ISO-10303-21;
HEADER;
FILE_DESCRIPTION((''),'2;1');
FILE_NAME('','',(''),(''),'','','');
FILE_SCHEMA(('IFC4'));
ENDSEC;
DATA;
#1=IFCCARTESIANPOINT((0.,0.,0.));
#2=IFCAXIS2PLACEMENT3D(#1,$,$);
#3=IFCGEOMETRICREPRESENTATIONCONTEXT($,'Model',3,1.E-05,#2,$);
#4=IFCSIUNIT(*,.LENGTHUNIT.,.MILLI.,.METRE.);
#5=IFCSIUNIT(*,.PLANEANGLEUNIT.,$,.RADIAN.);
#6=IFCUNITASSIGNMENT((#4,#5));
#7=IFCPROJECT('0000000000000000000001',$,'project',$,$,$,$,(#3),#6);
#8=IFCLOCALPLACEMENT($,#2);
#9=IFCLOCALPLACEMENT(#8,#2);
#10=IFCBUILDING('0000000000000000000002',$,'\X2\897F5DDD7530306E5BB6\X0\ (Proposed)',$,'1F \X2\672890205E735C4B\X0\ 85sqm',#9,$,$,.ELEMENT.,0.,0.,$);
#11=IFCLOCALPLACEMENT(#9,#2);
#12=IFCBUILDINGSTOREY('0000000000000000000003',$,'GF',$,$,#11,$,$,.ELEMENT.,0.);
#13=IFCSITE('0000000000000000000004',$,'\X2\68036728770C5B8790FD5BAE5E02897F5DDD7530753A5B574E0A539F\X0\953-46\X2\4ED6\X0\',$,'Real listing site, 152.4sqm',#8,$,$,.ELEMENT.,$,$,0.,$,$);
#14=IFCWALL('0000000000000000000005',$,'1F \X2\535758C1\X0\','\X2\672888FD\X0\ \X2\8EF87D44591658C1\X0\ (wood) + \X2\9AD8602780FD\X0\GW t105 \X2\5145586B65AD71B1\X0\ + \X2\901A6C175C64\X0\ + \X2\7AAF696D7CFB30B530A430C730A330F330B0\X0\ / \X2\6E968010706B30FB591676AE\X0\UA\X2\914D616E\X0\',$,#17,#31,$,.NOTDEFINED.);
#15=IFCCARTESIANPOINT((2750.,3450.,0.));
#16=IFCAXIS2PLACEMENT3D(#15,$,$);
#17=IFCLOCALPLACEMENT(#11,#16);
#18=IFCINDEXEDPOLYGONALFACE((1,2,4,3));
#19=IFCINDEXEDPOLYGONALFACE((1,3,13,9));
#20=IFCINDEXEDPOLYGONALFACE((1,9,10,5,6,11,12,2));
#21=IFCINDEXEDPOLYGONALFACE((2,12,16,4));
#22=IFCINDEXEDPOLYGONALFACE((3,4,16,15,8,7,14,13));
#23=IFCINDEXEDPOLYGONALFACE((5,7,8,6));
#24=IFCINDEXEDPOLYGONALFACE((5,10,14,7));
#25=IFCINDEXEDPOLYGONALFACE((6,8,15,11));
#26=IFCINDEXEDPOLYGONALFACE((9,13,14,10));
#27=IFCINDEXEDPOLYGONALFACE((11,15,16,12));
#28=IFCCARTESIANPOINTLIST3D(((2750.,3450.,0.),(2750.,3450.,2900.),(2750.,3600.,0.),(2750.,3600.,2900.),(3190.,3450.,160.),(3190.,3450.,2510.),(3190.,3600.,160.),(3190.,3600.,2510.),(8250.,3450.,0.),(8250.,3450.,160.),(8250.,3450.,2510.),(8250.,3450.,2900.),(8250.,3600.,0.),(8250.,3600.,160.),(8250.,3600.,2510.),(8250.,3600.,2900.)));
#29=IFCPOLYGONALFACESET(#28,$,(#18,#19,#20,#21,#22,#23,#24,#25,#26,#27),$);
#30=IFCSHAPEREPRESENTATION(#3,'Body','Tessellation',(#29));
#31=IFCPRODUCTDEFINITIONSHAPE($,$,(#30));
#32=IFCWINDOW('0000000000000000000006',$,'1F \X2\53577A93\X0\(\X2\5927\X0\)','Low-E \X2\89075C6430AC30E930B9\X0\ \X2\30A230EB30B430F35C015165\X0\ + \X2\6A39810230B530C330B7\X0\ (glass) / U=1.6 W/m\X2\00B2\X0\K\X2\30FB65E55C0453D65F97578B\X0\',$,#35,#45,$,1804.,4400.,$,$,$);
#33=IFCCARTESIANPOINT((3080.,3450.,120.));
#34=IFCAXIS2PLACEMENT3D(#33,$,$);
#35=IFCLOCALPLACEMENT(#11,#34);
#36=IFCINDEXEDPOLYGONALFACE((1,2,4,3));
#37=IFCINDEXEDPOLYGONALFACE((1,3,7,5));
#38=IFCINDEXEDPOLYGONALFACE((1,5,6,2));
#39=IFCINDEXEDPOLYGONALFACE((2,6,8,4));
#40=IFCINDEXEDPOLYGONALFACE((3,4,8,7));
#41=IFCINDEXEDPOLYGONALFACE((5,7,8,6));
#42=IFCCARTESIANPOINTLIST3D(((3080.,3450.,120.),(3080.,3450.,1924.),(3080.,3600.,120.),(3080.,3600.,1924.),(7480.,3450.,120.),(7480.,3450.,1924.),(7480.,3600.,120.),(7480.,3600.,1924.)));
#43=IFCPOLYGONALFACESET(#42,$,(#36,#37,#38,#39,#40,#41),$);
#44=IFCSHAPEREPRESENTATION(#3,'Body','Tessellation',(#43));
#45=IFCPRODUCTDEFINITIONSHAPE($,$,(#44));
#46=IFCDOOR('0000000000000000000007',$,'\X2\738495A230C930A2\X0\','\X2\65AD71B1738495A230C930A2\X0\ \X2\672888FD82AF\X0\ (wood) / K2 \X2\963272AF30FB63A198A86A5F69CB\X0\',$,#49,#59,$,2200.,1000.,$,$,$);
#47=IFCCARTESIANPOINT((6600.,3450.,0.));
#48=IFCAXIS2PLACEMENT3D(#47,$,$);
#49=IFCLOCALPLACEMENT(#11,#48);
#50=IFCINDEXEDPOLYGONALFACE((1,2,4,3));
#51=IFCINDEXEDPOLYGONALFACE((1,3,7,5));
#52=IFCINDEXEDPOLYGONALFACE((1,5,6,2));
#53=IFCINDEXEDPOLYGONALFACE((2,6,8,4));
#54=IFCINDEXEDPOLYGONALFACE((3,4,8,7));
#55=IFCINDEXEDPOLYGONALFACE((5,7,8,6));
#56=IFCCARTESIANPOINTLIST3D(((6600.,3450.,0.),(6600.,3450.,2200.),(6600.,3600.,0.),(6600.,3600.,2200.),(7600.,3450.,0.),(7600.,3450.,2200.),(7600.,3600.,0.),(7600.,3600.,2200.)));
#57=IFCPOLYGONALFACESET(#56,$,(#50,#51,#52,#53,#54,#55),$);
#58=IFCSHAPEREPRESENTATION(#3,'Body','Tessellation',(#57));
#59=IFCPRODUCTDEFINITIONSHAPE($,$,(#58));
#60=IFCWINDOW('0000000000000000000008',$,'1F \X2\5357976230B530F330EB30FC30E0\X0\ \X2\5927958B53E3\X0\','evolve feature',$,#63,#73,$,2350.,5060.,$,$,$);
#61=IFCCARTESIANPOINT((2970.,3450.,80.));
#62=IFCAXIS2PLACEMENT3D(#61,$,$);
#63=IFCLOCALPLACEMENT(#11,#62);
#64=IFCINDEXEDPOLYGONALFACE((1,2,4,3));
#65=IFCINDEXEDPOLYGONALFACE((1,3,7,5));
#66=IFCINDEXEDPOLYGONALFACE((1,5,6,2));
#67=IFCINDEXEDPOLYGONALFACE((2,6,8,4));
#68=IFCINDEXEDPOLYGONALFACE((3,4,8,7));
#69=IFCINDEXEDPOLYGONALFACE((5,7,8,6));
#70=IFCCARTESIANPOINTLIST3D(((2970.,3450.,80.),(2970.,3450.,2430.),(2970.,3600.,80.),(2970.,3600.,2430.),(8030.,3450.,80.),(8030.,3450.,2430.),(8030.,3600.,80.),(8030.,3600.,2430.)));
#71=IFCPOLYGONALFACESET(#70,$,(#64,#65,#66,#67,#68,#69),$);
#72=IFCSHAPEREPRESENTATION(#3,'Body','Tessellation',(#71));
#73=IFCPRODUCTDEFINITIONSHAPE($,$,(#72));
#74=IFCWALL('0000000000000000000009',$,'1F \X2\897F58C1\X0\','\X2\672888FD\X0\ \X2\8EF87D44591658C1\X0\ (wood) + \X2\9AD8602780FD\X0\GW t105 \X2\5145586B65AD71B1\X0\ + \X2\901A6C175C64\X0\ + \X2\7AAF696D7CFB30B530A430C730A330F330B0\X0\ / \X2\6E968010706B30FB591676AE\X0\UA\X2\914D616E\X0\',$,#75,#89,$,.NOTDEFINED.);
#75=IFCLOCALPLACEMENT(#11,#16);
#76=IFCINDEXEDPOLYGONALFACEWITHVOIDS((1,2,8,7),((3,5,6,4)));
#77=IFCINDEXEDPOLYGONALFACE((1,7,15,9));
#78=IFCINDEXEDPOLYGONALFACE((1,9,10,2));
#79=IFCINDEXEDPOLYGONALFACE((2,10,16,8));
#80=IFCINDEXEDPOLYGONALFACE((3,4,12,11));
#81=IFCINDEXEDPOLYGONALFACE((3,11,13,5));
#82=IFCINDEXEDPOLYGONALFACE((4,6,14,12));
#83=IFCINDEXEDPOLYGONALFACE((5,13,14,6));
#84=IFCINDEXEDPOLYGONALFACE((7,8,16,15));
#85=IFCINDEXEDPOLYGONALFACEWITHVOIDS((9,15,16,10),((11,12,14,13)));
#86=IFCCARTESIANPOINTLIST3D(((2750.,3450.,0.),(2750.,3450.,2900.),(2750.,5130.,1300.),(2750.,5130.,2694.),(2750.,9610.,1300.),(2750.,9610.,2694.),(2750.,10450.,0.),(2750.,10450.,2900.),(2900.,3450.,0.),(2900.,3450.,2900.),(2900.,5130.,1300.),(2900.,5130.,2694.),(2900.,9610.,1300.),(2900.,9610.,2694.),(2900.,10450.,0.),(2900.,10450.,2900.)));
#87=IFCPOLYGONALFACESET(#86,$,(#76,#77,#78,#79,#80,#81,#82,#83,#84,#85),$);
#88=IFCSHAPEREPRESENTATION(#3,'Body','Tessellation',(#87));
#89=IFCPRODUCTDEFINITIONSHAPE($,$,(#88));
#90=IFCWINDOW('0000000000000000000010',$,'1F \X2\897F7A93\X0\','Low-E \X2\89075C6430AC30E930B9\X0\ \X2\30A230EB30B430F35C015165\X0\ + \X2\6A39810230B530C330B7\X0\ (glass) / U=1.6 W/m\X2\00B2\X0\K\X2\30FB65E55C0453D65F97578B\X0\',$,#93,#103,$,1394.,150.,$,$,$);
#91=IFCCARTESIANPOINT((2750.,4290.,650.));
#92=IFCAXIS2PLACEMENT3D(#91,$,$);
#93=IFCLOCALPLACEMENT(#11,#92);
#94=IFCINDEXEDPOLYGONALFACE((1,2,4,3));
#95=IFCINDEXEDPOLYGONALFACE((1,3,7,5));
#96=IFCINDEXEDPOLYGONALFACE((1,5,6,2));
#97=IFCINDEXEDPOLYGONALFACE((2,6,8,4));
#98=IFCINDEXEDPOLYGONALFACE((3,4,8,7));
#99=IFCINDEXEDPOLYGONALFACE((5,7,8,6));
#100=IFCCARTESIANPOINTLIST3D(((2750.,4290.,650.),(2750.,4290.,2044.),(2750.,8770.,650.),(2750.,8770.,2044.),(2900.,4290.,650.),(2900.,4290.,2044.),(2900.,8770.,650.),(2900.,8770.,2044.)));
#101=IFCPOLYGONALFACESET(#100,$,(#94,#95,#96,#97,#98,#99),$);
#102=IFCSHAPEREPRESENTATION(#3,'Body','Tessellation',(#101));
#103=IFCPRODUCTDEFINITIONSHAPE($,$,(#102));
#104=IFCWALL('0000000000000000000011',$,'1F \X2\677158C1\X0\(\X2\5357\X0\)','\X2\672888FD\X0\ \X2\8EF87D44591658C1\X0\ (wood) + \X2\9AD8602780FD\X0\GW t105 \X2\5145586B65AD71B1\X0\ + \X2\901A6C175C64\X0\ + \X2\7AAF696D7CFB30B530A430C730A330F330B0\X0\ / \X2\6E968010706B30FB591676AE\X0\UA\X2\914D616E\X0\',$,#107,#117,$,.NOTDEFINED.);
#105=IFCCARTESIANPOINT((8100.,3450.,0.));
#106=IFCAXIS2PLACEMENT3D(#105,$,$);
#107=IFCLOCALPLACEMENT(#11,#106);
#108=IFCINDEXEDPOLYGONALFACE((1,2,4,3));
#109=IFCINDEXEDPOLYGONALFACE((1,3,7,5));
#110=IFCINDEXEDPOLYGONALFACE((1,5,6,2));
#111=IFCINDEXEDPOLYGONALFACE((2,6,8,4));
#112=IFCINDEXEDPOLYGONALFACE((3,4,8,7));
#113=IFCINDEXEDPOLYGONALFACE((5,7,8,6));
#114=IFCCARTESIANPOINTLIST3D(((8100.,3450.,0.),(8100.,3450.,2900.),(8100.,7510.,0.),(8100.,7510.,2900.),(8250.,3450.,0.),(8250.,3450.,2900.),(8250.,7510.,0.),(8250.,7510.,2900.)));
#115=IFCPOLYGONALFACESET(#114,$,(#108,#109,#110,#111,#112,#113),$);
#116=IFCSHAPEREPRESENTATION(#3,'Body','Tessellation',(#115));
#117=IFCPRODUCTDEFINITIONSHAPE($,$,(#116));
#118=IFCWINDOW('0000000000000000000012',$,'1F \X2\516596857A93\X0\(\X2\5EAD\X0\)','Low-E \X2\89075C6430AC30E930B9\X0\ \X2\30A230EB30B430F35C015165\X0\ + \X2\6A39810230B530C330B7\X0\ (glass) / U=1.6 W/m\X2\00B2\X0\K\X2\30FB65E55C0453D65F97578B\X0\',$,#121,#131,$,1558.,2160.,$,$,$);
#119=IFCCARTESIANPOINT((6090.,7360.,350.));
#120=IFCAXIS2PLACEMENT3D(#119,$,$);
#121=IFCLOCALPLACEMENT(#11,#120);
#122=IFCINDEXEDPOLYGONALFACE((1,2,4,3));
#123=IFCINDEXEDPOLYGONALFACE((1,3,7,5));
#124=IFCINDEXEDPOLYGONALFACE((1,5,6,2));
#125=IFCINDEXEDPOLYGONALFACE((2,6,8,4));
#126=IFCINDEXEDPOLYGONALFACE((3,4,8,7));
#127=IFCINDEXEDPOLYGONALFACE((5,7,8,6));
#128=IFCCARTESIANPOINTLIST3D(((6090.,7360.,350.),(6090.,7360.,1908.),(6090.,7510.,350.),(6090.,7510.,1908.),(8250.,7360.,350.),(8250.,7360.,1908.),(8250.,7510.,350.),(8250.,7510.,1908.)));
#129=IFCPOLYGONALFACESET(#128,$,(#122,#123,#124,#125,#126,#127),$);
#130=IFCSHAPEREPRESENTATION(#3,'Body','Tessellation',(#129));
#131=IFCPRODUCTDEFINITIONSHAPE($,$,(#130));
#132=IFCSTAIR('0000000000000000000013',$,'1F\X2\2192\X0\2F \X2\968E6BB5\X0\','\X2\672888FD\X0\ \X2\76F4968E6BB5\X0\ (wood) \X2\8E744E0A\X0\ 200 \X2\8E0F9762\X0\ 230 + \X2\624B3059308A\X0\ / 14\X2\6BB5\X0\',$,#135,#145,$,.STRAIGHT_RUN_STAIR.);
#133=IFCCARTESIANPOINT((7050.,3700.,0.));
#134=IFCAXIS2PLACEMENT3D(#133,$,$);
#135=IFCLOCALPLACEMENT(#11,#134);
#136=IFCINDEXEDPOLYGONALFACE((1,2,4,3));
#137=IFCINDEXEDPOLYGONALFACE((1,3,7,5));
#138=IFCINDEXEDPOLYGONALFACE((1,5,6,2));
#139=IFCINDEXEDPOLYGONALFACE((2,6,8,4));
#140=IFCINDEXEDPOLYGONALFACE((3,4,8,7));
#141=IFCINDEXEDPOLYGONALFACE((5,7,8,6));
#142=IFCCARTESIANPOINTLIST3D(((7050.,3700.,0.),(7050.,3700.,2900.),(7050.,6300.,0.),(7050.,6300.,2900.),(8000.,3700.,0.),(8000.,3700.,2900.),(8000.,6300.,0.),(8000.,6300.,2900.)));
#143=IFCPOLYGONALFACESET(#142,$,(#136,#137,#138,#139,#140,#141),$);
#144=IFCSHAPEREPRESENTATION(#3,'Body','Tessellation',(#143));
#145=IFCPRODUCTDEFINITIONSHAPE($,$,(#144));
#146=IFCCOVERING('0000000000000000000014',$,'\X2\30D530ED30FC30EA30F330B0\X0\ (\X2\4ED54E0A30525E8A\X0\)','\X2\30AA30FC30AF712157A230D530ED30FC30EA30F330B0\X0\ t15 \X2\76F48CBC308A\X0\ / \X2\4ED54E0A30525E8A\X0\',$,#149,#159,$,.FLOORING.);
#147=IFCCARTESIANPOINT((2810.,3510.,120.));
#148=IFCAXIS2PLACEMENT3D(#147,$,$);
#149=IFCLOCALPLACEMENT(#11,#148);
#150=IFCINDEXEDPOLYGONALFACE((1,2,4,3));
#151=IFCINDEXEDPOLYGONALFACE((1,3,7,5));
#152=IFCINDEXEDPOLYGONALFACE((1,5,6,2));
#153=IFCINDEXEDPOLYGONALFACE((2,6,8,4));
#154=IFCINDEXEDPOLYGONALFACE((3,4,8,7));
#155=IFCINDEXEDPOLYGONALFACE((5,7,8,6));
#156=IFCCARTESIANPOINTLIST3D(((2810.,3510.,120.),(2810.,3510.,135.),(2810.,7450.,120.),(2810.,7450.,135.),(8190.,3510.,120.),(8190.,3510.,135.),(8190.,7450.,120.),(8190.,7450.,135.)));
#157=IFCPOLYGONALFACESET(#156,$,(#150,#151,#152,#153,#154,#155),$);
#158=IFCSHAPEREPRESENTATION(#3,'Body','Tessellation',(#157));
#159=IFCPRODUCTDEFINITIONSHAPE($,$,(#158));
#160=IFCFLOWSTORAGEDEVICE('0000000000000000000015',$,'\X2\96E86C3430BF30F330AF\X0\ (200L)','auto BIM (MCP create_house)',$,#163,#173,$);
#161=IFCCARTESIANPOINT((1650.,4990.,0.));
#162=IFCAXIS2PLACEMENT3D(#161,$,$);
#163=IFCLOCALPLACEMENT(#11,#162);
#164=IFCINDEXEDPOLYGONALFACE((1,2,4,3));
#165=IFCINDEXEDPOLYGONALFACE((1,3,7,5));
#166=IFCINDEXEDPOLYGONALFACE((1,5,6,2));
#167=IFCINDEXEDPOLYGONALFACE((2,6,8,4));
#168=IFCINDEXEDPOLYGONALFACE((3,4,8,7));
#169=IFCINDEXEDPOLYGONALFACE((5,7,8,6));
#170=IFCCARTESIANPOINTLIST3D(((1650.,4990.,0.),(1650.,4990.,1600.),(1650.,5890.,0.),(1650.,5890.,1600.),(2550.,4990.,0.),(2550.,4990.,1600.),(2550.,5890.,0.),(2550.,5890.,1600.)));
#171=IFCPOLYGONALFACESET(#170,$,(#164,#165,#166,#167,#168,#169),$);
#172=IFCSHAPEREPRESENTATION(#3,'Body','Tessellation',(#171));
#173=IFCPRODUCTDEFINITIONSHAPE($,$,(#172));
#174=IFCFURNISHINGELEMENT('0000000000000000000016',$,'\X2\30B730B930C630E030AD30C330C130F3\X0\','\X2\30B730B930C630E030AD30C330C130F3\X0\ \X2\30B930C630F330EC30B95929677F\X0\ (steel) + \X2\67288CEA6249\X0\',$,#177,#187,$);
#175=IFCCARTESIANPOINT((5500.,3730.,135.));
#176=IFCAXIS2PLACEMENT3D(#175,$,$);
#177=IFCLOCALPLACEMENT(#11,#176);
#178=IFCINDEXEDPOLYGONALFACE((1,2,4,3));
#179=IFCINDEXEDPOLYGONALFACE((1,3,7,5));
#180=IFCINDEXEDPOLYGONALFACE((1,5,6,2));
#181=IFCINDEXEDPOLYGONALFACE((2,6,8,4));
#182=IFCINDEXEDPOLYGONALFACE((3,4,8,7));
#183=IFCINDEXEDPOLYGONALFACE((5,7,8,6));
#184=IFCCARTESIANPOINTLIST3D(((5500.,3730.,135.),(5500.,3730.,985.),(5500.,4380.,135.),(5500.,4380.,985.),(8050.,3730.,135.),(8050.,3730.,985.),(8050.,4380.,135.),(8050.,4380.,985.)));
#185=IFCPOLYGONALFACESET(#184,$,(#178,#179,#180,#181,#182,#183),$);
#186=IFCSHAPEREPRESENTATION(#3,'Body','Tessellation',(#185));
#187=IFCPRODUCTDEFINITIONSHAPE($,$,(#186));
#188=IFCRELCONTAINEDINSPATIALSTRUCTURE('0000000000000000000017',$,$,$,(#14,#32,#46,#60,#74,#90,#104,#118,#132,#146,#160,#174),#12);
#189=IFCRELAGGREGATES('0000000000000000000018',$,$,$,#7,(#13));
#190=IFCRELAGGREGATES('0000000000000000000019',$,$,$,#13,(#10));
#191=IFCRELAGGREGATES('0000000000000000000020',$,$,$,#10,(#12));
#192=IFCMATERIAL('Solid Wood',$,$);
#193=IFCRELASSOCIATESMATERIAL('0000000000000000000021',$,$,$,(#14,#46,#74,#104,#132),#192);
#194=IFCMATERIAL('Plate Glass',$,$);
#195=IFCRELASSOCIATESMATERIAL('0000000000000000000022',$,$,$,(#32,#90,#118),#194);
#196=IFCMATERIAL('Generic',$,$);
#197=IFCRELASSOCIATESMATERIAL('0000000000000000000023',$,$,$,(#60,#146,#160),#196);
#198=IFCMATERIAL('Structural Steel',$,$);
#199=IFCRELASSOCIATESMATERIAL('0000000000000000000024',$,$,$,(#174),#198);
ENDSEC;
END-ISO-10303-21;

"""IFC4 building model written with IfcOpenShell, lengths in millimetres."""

from ifc_helpers import new_model, si_unit, frame, frame_2d, origin, place, context, project, spatial, rectangle, extrude, material, element, fill, save


model = new_model("IFC4")

# Units and contexts
model_context = context("Model", 3, precision=1e-05, world=origin())
ifc_project = project(units=[si_unit("LENGTHUNIT", "METRE", prefix="MILLI"), si_unit("PLANEANGLEUNIT", "RADIAN")], contexts=[model_context])

# Site, building, storey
site_placement = place(None, origin())
site = spatial("IfcSite", under=ifc_project, at=site_placement, Name="栃木県宇都宮市西川田町字上原953-46他", ObjectType="Real listing site, 152.4sqm", CompositionType="ELEMENT", RefElevation=0.0)
building_placement = place(site_placement, origin())
building = spatial("IfcBuilding", under=site, at=building_placement, Name="西川田の家 (Proposed)", ObjectType="1F 木造平屋 85sqm", CompositionType="ELEMENT", ElevationOfRefHeight=0.0, ElevationOfTerrain=0.0)
storey_placement = place(building_placement, origin())
storey = spatial("IfcBuildingStorey", under=building, at=storey_placement, Name="GF", CompositionType="ELEMENT", Elevation=0.0)

# Shared definitions
ifc_material_1 = material(Name="Solid Wood")
ifc_material_2 = material(Name="Generic")

# Wall, openings, windows, door
wall_1_placement = place(storey_placement, frame((2750.0, 3450.0, 0.0)))
wall_1 = element("IfcWall", 1, at=wall_1_placement, inside=storey, material=ifc_material_1, Name="1F 南壁", Description="木製 軸組外壁 (wood) + 高性能GW t105 充填断熱 + 通気層 + 窯業系サイディング / 準耐火・外皮UA配慮", PredefinedType="NOTDEFINED", context=model_context, shape_type="SweptSolid", body=[
    extrude(rectangle(XDim=5500.0, YDim=150.0, at=frame_2d((2750.0, 75.0))), frame((2750.0, 3450.0, 0.0)), (0.0, 0.0, 1.0), 2900.0),
])
opening_1_placement = place(storey_placement, frame((3080.0, 3450.0, 120.0)))
opening_1 = element("IfcOpeningElement", 2, at=opening_1_placement, cuts=wall_1, PredefinedType="NOTDEFINED", context=model_context, shape_type="SweptSolid", body=[
    extrude(rectangle(XDim=4400.0, YDim=150.0, at=frame_2d((2200.0, 75.0))), frame((3080.0, 3450.0, 120.0)), (0.0, 0.0, 1.0), 1804.0),
])
opening_2_placement = place(storey_placement, frame((6600.0, 3450.0, 0.0)))
opening_2 = element("IfcOpeningElement", 3, at=opening_2_placement, cuts=wall_1, PredefinedType="NOTDEFINED", context=model_context, shape_type="SweptSolid", body=[
    extrude(rectangle(XDim=1000.0, YDim=150.0, at=frame_2d((500.0, 75.0))), frame((6600.0, 3450.0, 0.0)), (0.0, 0.0, 1.0), 2200.0),
])
opening_3_placement = place(storey_placement, frame((2970.0, 3450.0, 80.0)))
opening_3 = element("IfcOpeningElement", 4, at=opening_3_placement, cuts=wall_1, PredefinedType="NOTDEFINED", context=model_context, shape_type="SweptSolid", body=[
    extrude(rectangle(XDim=5060.0, YDim=150.0, at=frame_2d((2530.0, 75.0))), frame((2970.0, 3450.0, 80.0)), (0.0, 0.0, 1.0), 2350.0),
])
ifc_material_3 = material(Name="Plate Glass")
window_1_placement = place(storey_placement, frame((3080.0, 3450.0, 120.0)))
window_1 = element("IfcWindow", 5, at=window_1_placement, inside=storey, material=ifc_material_3, Name="1F 南窓(大)", Description="Low-E 複層ガラス アルゴン封入 + 樹脂サッシ (glass) / U=1.6 W/m²K・日射取得型", OverallHeight=1804.0, OverallWidth=4400.0, context=model_context, shape_type="SweptSolid", body=[
    extrude(rectangle(XDim=4400.0, YDim=150.0, at=frame_2d((2200.0, 75.0))), frame((3080.0, 3450.0, 120.0)), (0.0, 0.0, 1.0), 1804.0),
])
fill(opening_1, window_1)
door_1_placement = place(storey_placement, frame((6600.0, 3450.0, 0.0)))
door_1 = element("IfcDoor", 6, at=door_1_placement, inside=storey, material=ifc_material_1, Name="玄関ドア", Description="断熱玄関ドア 木製芯 (wood) / K2 防犯・採風機構", OverallHeight=2200.0, OverallWidth=1000.0, context=model_context, shape_type="SweptSolid", body=[
    extrude(rectangle(XDim=1000.0, YDim=150.0, at=frame_2d((500.0, 75.0))), frame((6600.0, 3450.0, 0.0)), (0.0, 0.0, 1.0), 2200.0),
])
fill(opening_2, door_1)
window_2_placement = place(storey_placement, frame((2970.0, 3450.0, 80.0)))
window_2 = element("IfcWindow", 7, at=window_2_placement, inside=storey, material=ifc_material_2, Name="1F 南面サンルーム 大開口", Description="evolve feature", OverallHeight=2350.0, OverallWidth=5060.0, context=model_context, shape_type="SweptSolid", body=[
    extrude(rectangle(XDim=5060.0, YDim=150.0, at=frame_2d((2530.0, 75.0))), frame((2970.0, 3450.0, 80.0)), (0.0, 0.0, 1.0), 2350.0),
])
fill(opening_3, window_2)

# Walls, openings, windows
wall_2_placement = place(storey_placement, frame((2750.0, 3450.0, 0.0)))
wall_2 = element("IfcWall", 8, at=wall_2_placement, inside=storey, material=ifc_material_1, Name="1F 西壁", Description="木製 軸組外壁 (wood) + 高性能GW t105 充填断熱 + 通気層 + 窯業系サイディング / 準耐火・外皮UA配慮", PredefinedType="NOTDEFINED", context=model_context, shape_type="SweptSolid", body=[
    extrude(rectangle(XDim=150.0, YDim=7000.0, at=frame_2d((75.0, 3500.0))), frame((2750.0, 3450.0, 0.0)), (0.0, 0.0, 1.0), 2900.0),
])
opening_4_placement = place(storey_placement, frame((2750.0, 4290.0, 650.0)))
opening_4 = element("IfcOpeningElement", 9, at=opening_4_placement, cuts=wall_2, PredefinedType="NOTDEFINED", context=model_context, shape_type="SweptSolid", body=[
    extrude(rectangle(XDim=150.0, YDim=4480.0, at=frame_2d((75.0, 2240.0))), frame((2750.0, 4290.0, 650.0)), (0.0, 0.0, 1.0), 1394.0),
])
window_3_placement = place(storey_placement, frame((2750.0, 4290.0, 650.0)))
window_3 = element("IfcWindow", 10, at=window_3_placement, inside=storey, material=ifc_material_3, Name="1F 西窓", Description="Low-E 複層ガラス アルゴン封入 + 樹脂サッシ (glass) / U=1.6 W/m²K・日射取得型", OverallHeight=1394.0, OverallWidth=150.0, context=model_context, shape_type="SweptSolid", body=[
    extrude(rectangle(XDim=150.0, YDim=4480.0, at=frame_2d((75.0, 2240.0))), frame((2750.0, 4290.0, 650.0)), (0.0, 0.0, 1.0), 1394.0),
])
fill(opening_4, window_3)
wall_3_placement = place(storey_placement, frame((8100.0, 3450.0, 0.0)))
wall_3 = element("IfcWall", 11, at=wall_3_placement, inside=storey, material=ifc_material_1, Name="1F 東壁(南)", Description="木製 軸組外壁 (wood) + 高性能GW t105 充填断熱 + 通気層 + 窯業系サイディング / 準耐火・外皮UA配慮", PredefinedType="NOTDEFINED", context=model_context, shape_type="SweptSolid", body=[
    extrude(rectangle(XDim=150.0, YDim=4060.0, at=frame_2d((75.0, 2030.0))), frame((8100.0, 3450.0, 0.0)), (0.0, 0.0, 1.0), 2900.0),
])
opening_5_placement = place(storey_placement, frame((6090.0, 7360.0, 350.0)))
opening_5 = element("IfcOpeningElement", 12, at=opening_5_placement, cuts=wall_3, PredefinedType="NOTDEFINED", context=model_context, shape_type="SweptSolid", body=[
    extrude(rectangle(XDim=2160.0, YDim=150.0, at=frame_2d((1080.0, 75.0))), frame((6090.0, 7360.0, 350.0)), (0.0, 0.0, 1.0), 1558.0),
])
window_4_placement = place(storey_placement, frame((6090.0, 7360.0, 350.0)))
window_4 = element("IfcWindow", 13, at=window_4_placement, inside=storey, material=ifc_material_3, Name="1F 入隅窓(庭)", Description="Low-E 複層ガラス アルゴン封入 + 樹脂サッシ (glass) / U=1.6 W/m²K・日射取得型", OverallHeight=1558.0, OverallWidth=2160.0, context=model_context, shape_type="SweptSolid", body=[
    extrude(rectangle(XDim=2160.0, YDim=150.0, at=frame_2d((1080.0, 75.0))), frame((6090.0, 7360.0, 350.0)), (0.0, 0.0, 1.0), 1558.0),
])
fill(opening_5, window_4)

# Stair
stair_placement = place(storey_placement, frame((7050.0, 3700.0, 0.0)))
element("IfcStair", 14, at=stair_placement, inside=storey, material=ifc_material_1, Name="1F→2F 階段", Description="木製 直階段 (wood) 蹴上 200 踏面 230 + 手すり / 14段", PredefinedType="STRAIGHT_RUN_STAIR", context=model_context, shape_type="SweptSolid", body=[
    extrude(rectangle(XDim=950.0, YDim=2600.0, at=frame_2d((475.0, 1300.0))), frame((7050.0, 3700.0, 0.0)), (0.0, 0.0, 1.0), 2900.0),
])

# Covering
covering_placement = place(storey_placement, frame((2810.0, 3510.0, 120.0)))
element("IfcCovering", 15, at=covering_placement, inside=storey, material=ifc_material_2, Name="フローリング (仕上げ床)", Description="オーク無垢フローリング t15 直貼り / 仕上げ床", PredefinedType="FLOORING", context=model_context, shape_type="SweptSolid", body=[
    extrude(rectangle(XDim=5380.0, YDim=3940.0, at=frame_2d((2690.0, 1970.0))), frame((2810.0, 3510.0, 120.0)), (0.0, 0.0, 1.0), 15.0),
])

# Flow storage device
flow_storage_device_placement = place(storey_placement, frame((1650.0, 4990.0, 0.0)))
element("IfcFlowStorageDevice", 16, at=flow_storage_device_placement, inside=storey, material=ifc_material_2, Name="雨水タンク (200L)", Description="auto BIM (MCP create_house)", context=model_context, shape_type="SweptSolid", body=[
    extrude(rectangle(XDim=900.0, YDim=900.0, at=frame_2d((450.0, 450.0))), frame((1650.0, 4990.0, 0.0)), (0.0, 0.0, 1.0), 1600.0),
])

# Furnishing element
ifc_material_4 = material(Name="Structural Steel")
furnishing_placement = place(storey_placement, frame((5500.0, 3730.0, 135.0)))
element("IfcFurnishingElement", 17, at=furnishing_placement, inside=storey, material=ifc_material_4, Name="システムキッチン", Description="システムキッチン ステンレス天板 (steel) + 木質扉", context=model_context, shape_type="SweptSolid", body=[
    extrude(rectangle(XDim=2550.0, YDim=650.0, at=frame_2d((1275.0, 325.0))), frame((5500.0, 3730.0, 135.0)), (0.0, 0.0, 1.0), 850.0),
])

save(model, "model.ifc")
